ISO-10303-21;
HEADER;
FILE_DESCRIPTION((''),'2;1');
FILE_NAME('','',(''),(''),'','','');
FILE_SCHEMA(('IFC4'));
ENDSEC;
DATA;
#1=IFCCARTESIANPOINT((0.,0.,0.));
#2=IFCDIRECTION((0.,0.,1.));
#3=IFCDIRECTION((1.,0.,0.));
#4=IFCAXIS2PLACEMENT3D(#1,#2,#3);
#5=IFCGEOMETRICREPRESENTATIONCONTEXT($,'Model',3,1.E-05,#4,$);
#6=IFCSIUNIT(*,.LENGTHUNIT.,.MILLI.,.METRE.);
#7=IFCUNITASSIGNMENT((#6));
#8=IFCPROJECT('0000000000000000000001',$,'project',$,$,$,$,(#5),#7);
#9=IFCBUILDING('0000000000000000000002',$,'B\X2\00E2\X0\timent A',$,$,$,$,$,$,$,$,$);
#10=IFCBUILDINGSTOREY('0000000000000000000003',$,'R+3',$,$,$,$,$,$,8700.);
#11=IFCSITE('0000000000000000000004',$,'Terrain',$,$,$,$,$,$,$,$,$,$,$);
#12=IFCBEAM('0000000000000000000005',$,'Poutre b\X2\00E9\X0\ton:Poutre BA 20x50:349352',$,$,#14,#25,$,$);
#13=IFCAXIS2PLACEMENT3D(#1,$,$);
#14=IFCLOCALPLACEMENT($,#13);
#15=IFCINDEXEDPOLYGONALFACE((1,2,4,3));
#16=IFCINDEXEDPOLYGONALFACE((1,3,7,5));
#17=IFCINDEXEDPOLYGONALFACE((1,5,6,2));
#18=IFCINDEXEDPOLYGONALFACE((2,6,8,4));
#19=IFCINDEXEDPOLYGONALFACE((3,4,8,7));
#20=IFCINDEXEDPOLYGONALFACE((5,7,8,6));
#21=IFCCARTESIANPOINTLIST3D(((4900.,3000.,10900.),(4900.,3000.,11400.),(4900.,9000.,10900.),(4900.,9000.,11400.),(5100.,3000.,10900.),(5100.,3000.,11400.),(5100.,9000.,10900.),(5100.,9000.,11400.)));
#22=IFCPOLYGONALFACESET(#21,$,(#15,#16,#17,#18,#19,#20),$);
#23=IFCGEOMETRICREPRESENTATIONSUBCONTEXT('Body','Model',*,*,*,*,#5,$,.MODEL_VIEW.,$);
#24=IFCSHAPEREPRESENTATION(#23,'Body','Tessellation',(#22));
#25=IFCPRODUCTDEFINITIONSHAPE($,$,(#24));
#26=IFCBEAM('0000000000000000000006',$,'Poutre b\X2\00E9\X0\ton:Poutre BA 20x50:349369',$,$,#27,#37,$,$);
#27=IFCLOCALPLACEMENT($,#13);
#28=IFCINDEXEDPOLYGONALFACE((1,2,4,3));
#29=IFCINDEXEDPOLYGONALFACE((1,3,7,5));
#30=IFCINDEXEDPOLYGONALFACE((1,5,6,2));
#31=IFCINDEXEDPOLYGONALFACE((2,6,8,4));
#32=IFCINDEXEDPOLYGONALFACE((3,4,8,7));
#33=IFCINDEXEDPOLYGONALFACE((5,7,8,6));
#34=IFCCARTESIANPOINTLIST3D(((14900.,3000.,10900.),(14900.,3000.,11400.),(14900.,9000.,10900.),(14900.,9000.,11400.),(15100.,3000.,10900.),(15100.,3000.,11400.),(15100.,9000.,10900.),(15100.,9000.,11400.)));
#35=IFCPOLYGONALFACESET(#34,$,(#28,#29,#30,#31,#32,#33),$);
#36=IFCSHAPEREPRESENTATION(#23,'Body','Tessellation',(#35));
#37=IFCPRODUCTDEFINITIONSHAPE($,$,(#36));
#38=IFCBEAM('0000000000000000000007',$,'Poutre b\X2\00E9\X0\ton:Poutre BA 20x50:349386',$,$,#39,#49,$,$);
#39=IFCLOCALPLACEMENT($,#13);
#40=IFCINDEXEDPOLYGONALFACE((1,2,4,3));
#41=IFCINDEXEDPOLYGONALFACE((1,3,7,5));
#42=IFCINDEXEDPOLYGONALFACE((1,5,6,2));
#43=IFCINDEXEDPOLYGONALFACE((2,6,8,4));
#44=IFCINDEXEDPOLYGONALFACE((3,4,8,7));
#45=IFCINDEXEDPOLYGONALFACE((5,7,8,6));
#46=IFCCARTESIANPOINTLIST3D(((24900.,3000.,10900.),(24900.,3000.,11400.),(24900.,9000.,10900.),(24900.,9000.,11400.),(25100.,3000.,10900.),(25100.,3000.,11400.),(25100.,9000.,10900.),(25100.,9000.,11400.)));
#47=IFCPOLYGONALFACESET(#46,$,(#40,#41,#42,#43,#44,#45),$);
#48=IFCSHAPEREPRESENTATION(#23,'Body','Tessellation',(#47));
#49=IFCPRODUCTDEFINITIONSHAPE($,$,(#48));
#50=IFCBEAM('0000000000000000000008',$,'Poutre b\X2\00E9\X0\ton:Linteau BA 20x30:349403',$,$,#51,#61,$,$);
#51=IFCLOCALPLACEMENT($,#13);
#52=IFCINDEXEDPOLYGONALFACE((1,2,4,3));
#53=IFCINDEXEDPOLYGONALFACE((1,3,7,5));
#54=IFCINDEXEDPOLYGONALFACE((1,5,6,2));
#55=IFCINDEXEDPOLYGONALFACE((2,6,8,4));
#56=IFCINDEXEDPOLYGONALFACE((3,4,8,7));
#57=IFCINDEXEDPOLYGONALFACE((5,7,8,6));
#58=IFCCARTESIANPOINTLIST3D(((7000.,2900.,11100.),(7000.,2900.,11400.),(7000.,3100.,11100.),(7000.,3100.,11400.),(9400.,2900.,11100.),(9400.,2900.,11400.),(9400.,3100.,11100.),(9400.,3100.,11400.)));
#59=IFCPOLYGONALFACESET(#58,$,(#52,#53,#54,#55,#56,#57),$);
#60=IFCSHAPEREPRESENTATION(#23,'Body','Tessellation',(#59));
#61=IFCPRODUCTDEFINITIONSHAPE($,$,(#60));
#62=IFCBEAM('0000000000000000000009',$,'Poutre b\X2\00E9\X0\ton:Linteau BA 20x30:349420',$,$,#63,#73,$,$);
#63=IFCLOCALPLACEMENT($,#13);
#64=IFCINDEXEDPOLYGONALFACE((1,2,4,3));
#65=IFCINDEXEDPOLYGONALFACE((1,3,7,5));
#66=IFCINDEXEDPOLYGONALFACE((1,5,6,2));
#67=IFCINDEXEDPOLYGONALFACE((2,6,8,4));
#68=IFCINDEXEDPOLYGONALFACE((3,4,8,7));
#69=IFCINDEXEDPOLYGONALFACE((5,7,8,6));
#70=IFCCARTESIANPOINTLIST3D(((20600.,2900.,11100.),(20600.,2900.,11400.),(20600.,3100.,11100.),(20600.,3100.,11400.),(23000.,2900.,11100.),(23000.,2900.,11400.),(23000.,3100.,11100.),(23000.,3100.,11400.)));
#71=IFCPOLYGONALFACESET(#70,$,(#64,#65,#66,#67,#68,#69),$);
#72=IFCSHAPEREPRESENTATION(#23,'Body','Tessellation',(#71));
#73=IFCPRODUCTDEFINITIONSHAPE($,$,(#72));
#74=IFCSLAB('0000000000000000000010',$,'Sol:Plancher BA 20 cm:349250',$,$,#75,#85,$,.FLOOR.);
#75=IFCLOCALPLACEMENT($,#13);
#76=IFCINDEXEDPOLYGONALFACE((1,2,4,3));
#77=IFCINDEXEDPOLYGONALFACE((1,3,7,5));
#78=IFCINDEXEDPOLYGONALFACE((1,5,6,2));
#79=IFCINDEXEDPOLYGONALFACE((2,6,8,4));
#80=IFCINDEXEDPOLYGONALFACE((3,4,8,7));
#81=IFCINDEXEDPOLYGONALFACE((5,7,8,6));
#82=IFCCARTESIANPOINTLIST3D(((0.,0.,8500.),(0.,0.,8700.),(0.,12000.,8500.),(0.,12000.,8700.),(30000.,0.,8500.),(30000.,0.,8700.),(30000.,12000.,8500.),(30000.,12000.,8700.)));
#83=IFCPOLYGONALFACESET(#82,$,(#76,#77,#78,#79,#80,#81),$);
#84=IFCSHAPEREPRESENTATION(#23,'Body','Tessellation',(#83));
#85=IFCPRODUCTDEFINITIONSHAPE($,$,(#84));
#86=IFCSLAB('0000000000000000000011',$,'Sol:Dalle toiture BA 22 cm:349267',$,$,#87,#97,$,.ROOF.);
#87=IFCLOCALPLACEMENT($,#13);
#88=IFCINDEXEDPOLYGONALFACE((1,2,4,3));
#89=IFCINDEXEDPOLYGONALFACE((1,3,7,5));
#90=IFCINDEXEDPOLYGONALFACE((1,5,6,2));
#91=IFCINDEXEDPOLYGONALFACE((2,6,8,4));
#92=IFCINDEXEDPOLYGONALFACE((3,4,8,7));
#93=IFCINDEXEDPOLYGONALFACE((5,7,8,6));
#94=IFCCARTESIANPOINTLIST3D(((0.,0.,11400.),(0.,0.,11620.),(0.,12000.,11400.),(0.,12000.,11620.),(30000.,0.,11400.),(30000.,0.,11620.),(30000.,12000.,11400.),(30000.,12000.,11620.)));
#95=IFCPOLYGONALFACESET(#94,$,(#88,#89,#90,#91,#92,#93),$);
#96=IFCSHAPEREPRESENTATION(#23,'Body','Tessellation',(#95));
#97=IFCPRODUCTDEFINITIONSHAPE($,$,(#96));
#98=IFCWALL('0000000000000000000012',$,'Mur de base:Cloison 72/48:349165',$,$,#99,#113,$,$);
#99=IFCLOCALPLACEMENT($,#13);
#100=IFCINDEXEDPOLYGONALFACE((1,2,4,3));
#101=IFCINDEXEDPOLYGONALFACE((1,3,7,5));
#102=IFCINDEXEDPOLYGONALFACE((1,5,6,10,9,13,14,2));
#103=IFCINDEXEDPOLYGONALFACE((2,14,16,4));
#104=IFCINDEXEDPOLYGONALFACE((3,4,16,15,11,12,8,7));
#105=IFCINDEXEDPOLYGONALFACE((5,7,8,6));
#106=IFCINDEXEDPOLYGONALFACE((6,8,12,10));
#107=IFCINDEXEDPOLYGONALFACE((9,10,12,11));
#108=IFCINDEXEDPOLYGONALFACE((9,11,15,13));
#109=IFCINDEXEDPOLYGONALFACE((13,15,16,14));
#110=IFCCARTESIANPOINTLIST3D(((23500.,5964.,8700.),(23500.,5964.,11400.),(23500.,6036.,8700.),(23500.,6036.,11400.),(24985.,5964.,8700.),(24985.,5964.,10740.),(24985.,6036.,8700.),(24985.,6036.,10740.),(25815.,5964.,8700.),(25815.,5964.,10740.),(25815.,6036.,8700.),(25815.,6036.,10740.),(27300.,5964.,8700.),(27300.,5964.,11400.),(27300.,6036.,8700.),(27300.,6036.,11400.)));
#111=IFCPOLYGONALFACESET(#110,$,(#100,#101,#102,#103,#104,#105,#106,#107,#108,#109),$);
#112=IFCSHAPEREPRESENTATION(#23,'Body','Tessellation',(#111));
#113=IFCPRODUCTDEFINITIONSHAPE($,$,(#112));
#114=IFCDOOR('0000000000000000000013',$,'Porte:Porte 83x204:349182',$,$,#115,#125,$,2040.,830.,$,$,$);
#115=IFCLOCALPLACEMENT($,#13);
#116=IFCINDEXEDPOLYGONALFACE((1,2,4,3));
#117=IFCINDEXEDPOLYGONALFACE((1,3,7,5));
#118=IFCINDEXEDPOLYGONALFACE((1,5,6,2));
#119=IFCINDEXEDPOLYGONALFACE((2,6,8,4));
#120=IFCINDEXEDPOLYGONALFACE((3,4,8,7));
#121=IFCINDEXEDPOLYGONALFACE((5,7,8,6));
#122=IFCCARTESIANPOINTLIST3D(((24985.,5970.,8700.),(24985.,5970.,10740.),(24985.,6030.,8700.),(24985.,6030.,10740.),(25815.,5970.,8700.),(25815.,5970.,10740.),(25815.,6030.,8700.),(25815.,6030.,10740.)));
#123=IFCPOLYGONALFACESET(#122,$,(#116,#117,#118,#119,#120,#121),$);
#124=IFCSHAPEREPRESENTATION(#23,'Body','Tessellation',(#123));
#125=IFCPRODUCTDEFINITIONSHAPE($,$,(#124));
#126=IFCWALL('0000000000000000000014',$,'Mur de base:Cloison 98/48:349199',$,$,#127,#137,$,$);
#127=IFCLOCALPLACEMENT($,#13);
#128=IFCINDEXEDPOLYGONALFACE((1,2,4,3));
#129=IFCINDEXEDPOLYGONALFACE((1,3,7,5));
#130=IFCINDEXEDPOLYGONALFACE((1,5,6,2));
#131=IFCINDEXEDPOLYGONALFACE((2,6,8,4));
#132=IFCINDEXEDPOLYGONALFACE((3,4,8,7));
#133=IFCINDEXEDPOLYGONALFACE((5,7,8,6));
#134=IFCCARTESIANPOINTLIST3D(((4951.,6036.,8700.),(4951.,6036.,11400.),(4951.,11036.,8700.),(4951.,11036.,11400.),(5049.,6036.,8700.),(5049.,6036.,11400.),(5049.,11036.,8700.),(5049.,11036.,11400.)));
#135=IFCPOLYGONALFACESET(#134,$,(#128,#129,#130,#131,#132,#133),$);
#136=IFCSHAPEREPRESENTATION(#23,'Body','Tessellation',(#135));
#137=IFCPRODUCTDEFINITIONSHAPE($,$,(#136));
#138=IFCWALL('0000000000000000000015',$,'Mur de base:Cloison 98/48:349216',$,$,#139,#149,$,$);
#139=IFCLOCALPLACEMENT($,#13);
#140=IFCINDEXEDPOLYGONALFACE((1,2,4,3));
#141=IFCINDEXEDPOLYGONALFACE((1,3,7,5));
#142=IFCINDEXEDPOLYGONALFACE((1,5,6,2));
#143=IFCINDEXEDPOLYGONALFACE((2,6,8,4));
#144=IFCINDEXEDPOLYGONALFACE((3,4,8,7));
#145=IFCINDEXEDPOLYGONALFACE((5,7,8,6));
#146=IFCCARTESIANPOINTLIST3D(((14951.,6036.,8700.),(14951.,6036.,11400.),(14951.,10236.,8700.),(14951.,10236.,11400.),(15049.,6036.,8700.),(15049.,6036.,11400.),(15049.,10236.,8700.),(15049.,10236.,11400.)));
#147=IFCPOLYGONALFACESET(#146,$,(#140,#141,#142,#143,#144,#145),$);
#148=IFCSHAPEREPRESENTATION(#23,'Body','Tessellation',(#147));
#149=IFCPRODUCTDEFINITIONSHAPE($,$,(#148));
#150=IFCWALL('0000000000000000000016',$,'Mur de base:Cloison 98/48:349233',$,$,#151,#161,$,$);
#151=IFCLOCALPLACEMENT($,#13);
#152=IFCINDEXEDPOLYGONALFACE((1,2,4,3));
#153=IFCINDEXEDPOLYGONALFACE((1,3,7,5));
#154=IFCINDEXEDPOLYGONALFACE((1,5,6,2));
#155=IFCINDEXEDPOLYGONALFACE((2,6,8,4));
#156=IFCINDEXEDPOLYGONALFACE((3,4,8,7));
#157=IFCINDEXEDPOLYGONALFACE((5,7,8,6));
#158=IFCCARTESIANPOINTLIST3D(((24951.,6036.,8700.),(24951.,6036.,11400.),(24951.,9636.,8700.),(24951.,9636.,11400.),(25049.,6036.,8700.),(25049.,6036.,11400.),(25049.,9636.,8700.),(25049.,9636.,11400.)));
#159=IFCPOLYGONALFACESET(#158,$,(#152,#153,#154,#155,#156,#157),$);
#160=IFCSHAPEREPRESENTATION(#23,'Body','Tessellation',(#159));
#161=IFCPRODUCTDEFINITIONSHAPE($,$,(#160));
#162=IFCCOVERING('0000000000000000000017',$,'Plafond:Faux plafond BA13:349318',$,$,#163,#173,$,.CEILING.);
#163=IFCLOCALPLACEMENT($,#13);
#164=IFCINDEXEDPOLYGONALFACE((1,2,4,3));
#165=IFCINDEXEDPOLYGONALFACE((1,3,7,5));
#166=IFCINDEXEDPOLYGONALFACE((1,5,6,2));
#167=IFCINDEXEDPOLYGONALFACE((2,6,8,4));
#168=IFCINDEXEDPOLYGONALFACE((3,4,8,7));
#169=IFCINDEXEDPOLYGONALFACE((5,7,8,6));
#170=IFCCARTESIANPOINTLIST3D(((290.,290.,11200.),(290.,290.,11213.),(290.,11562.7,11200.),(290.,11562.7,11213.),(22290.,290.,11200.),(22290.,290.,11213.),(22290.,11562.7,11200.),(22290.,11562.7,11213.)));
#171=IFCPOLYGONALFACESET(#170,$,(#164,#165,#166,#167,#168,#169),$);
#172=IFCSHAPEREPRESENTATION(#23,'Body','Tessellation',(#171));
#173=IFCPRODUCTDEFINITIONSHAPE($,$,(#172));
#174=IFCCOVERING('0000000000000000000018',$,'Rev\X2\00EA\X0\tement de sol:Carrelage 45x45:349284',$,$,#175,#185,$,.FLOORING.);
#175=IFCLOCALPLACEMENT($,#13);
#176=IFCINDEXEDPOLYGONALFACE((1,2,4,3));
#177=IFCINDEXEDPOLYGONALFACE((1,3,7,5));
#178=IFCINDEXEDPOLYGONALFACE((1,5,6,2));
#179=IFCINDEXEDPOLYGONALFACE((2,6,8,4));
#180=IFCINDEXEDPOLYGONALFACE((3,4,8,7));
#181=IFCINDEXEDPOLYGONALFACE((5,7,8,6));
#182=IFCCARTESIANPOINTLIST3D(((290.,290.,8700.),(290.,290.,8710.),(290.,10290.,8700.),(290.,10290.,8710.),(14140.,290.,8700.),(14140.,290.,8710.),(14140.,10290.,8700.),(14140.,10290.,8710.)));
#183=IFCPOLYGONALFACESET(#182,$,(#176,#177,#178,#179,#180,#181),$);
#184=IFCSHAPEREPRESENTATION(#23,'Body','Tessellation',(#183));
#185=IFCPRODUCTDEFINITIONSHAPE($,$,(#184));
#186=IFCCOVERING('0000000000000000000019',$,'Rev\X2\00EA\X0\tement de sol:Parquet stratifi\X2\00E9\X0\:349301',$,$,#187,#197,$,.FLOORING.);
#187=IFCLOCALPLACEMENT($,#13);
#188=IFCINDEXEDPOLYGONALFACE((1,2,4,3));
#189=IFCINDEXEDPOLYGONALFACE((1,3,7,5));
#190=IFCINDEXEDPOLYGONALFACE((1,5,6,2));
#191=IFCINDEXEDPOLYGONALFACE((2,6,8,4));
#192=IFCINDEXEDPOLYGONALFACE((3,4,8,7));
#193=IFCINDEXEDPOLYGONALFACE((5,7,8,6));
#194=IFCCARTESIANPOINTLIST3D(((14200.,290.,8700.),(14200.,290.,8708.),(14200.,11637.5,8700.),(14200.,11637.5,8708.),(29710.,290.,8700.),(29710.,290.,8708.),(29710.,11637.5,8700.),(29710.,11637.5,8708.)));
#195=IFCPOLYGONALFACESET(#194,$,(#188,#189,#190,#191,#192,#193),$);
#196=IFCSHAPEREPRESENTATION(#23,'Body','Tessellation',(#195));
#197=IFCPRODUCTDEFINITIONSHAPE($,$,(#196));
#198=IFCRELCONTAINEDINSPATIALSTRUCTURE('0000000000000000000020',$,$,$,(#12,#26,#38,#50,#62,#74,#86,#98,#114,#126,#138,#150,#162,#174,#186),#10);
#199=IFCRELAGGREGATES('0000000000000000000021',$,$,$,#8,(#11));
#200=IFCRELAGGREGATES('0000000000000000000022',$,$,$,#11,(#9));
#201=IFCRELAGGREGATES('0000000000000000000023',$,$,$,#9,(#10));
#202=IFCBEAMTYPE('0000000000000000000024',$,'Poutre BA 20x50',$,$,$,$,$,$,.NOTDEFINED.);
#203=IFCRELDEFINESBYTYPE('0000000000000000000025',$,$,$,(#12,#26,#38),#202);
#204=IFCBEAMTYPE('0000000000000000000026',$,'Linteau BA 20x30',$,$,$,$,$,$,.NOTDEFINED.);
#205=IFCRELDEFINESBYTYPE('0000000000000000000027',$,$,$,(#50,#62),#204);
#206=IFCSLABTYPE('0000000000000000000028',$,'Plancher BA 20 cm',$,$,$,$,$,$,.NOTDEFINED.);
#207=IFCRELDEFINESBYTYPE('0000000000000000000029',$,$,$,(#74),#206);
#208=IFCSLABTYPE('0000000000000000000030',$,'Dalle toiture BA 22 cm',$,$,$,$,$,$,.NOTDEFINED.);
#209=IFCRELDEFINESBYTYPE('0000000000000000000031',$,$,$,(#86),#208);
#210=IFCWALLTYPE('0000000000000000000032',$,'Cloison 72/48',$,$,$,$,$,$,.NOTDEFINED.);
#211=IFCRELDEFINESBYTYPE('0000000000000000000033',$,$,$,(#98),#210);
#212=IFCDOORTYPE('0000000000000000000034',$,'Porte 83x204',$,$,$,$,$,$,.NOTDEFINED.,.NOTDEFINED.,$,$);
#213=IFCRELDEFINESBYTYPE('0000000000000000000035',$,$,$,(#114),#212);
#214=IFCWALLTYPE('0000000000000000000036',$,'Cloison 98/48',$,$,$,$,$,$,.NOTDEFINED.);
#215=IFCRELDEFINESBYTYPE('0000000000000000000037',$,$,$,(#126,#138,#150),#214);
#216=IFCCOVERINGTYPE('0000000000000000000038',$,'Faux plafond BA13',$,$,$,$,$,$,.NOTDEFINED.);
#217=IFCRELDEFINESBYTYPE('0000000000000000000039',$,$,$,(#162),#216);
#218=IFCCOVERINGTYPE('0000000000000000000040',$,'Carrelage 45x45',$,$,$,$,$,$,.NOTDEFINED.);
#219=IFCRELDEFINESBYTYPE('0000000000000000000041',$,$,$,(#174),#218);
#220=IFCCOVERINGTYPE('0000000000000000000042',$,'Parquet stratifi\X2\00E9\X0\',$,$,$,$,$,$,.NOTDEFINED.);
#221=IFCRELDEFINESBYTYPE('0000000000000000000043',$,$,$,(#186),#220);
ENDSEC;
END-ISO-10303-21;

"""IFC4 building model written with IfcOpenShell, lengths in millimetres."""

from ifc_helpers import new_model, si_unit, frame, frame_2d, origin_with_axes, place, context, subcontext, project, spatial, rectangle, extrude, type_object, element, fill, save


model = new_model("IFC4")

# Units and contexts
model_context = context("Model", 3, precision=1e-05, world=origin_with_axes())
body_context = subcontext(model_context, "Body", "Model", "MODEL_VIEW")
ifc_project = project(units=[si_unit("LENGTHUNIT", "METRE", prefix="MILLI")], contexts=[model_context])

# Site, building, storey
site = spatial("IfcSite", under=ifc_project, Name="Terrain")
building = spatial("IfcBuilding", under=site, Name="Bâtiment A")
storey = spatial("IfcBuildingStorey", under=building, Name="R+3", Elevation=8700.0)

# Beams
beam_type_1 = type_object("IfcBeamType", Name="Poutre BA 20x50", PredefinedType="NOTDEFINED")
beam_1_placement = place(None, origin_with_axes())
element("IfcBeam", 1, at=beam_1_placement, inside=storey, type_object=beam_type_1, Name="Poutre béton:Poutre BA 20x50:349352", context=body_context, shape_type="SweptSolid", body=[
    extrude(rectangle(XDim=200.0, YDim=6000.0, at=frame_2d((5000.0, 6000.0))), frame((0.0, 0.0, 10900.0), z_axis=(0.0, 0.0, 1.0), x_axis=(1.0, 0.0, 0.0)), (0.0, 0.0, 1.0), 500.0),
])
beam_2_placement = place(None, origin_with_axes())
element("IfcBeam", 2, at=beam_2_placement, inside=storey, type_object=beam_type_1, Name="Poutre béton:Poutre BA 20x50:349369", context=body_context, shape_type="SweptSolid", body=[
    extrude(rectangle(XDim=200.0, YDim=6000.0, at=frame_2d((15000.0, 6000.0))), frame((0.0, 0.0, 10900.0), z_axis=(0.0, 0.0, 1.0), x_axis=(1.0, 0.0, 0.0)), (0.0, 0.0, 1.0), 500.0),
])
beam_3_placement = place(None, origin_with_axes())
element("IfcBeam", 3, at=beam_3_placement, inside=storey, type_object=beam_type_1, Name="Poutre béton:Poutre BA 20x50:349386", context=body_context, shape_type="SweptSolid", body=[
    extrude(rectangle(XDim=200.0, YDim=6000.0, at=frame_2d((25000.0, 6000.0))), frame((0.0, 0.0, 10900.0), z_axis=(0.0, 0.0, 1.0), x_axis=(1.0, 0.0, 0.0)), (0.0, 0.0, 1.0), 500.0),
])
beam_type_2 = type_object("IfcBeamType", Name="Linteau BA 20x30", PredefinedType="NOTDEFINED")
beam_4_placement = place(None, origin_with_axes())
element("IfcBeam", 4, at=beam_4_placement, inside=storey, type_object=beam_type_2, Name="Poutre béton:Linteau BA 20x30:349403", context=body_context, shape_type="SweptSolid", body=[
    extrude(rectangle(XDim=2400.0, YDim=200.0, at=frame_2d((8200.0, 3000.0))), frame((0.0, 0.0, 11100.0), z_axis=(0.0, 0.0, 1.0), x_axis=(1.0, 0.0, 0.0)), (0.0, 0.0, 1.0), 300.0),
])
beam_5_placement = place(None, origin_with_axes())
element("IfcBeam", 5, at=beam_5_placement, inside=storey, type_object=beam_type_2, Name="Poutre béton:Linteau BA 20x30:349420", context=body_context, shape_type="SweptSolid", body=[
    extrude(rectangle(XDim=2400.0, YDim=200.0, at=frame_2d((21800.0, 3000.0))), frame((0.0, 0.0, 11100.0), z_axis=(0.0, 0.0, 1.0), x_axis=(1.0, 0.0, 0.0)), (0.0, 0.0, 1.0), 300.0),
])

# Slabs
slab_type_1 = type_object("IfcSlabType", Name="Plancher BA 20 cm", PredefinedType="NOTDEFINED")
slab_1_placement = place(None, origin_with_axes())
element("IfcSlab", 6, at=slab_1_placement, inside=storey, type_object=slab_type_1, Name="Sol:Plancher BA 20 cm:349250", PredefinedType="FLOOR", context=body_context, shape_type="SweptSolid", body=[
    extrude(rectangle(XDim=30000.0, YDim=12000.0, at=frame_2d((15000.0, 6000.0))), frame((0.0, 0.0, 8500.0), z_axis=(0.0, 0.0, 1.0), x_axis=(1.0, 0.0, 0.0)), (0.0, 0.0, 1.0), 200.0),
])
slab_type_2 = type_object("IfcSlabType", Name="Dalle toiture BA 22 cm", PredefinedType="NOTDEFINED")
slab_2_placement = place(None, origin_with_axes())
element("IfcSlab", 7, at=slab_2_placement, inside=storey, type_object=slab_type_2, Name="Sol:Dalle toiture BA 22 cm:349267", PredefinedType="ROOF", context=body_context, shape_type="SweptSolid", body=[
    extrude(rectangle(XDim=30000.0, YDim=12000.0, at=frame_2d((15000.0, 6000.0))), frame((0.0, 0.0, 11400.0), z_axis=(0.0, 0.0, 1.0), x_axis=(1.0, 0.0, 0.0)), (0.0, 0.0, 1.0), 220.0),
])

# Wall, opening, door
wall_type_1 = type_object("IfcWallType", Name="Cloison 72/48", PredefinedType="NOTDEFINED")
wall_1_placement = place(None, origin_with_axes())
wall_1 = element("IfcWall", 8, at=wall_1_placement, inside=storey, type_object=wall_type_1, Name="Mur de base:Cloison 72/48:349165", context=body_context, shape_type="SweptSolid", body=[
    extrude(rectangle(XDim=3800.0, YDim=72.0, at=frame_2d((25400.0, 6000.0))), frame((0.0, 0.0, 8700.0), z_axis=(0.0, 0.0, 1.0), x_axis=(1.0, 0.0, 0.0)), (0.0, 0.0, 1.0), 2700.0),
])
opening_placement = place(None, origin_with_axes())
opening = element("IfcOpeningElement", 9, at=opening_placement, cuts=wall_1, context=body_context, shape_type="SweptSolid", body=[
    extrude(rectangle(XDim=830.0, YDim=192.0, at=frame_2d((25400.0, 6000.0))), frame((0.0, 0.0, 8700.0), z_axis=(0.0, 0.0, 1.0), x_axis=(1.0, 0.0, 0.0)), (0.0, 0.0, 1.0), 2040.0),
])
door_type = type_object("IfcDoorType", Name="Porte 83x204", OperationType="NOTDEFINED", PredefinedType="NOTDEFINED")
door_placement = place(None, origin_with_axes())
door = element("IfcDoor", 10, at=door_placement, inside=storey, type_object=door_type, Name="Porte:Porte 83x204:349182", OverallHeight=2040.0, OverallWidth=830.0, context=body_context, shape_type="SweptSolid", body=[
    extrude(rectangle(XDim=830.0, YDim=60.0, at=frame_2d((25400.0, 6000.0))), frame((0.0, 0.0, 8700.0), z_axis=(0.0, 0.0, 1.0), x_axis=(1.0, 0.0, 0.0)), (0.0, 0.0, 1.0), 2040.0),
])
fill(opening, door)

# Walls
wall_type_2 = type_object("IfcWallType", Name="Cloison 98/48", PredefinedType="NOTDEFINED")
wall_2_placement = place(None, origin_with_axes())
element("IfcWall", 11, at=wall_2_placement, inside=storey, type_object=wall_type_2, Name="Mur de base:Cloison 98/48:349199", context=body_context, shape_type="SweptSolid", body=[
    extrude(rectangle(XDim=98.0, YDim=5000.0, at=frame_2d((5000.0, 8536.0))), frame((0.0, 0.0, 8700.0), z_axis=(0.0, 0.0, 1.0), x_axis=(1.0, 0.0, 0.0)), (0.0, 0.0, 1.0), 2700.0),
])
wall_3_placement = place(None, origin_with_axes())
element("IfcWall", 12, at=wall_3_placement, inside=storey, type_object=wall_type_2, Name="Mur de base:Cloison 98/48:349216", context=body_context, shape_type="SweptSolid", body=[
    extrude(rectangle(XDim=98.0, YDim=4200.0, at=frame_2d((15000.0, 8136.0))), frame((0.0, 0.0, 8700.0), z_axis=(0.0, 0.0, 1.0), x_axis=(1.0, 0.0, 0.0)), (0.0, 0.0, 1.0), 2700.0),
])
wall_4_placement = place(None, origin_with_axes())
element("IfcWall", 13, at=wall_4_placement, inside=storey, type_object=wall_type_2, Name="Mur de base:Cloison 98/48:349233", context=body_context, shape_type="SweptSolid", body=[
    extrude(rectangle(XDim=98.0, YDim=3600.0, at=frame_2d((25000.0, 7836.0))), frame((0.0, 0.0, 8700.0), z_axis=(0.0, 0.0, 1.0), x_axis=(1.0, 0.0, 0.0)), (0.0, 0.0, 1.0), 2700.0),
])

# Coverings
covering_type_1 = type_object("IfcCoveringType", Name="Faux plafond BA13", PredefinedType="NOTDEFINED")
covering_1_placement = place(None, origin_with_axes())
element("IfcCovering", 14, at=covering_1_placement, inside=storey, type_object=covering_type_1, Name="Plafond:Faux plafond BA13:349318", PredefinedType="CEILING", context=body_context, shape_type="SweptSolid", body=[
    extrude(rectangle(XDim=22000.0, YDim=11272.7, at=frame_2d((11290.0, 5926.4))), frame((0.0, 0.0, 11200.0), z_axis=(0.0, 0.0, 1.0), x_axis=(1.0, 0.0, 0.0)), (0.0, 0.0, 1.0), 13.0),
])
covering_type_2 = type_object("IfcCoveringType", Name="Carrelage 45x45", PredefinedType="NOTDEFINED")
covering_2_placement = place(None, origin_with_axes())
element("IfcCovering", 15, at=covering_2_placement, inside=storey, type_object=covering_type_2, Name="Revêtement de sol:Carrelage 45x45:349284", PredefinedType="FLOORING", context=body_context, shape_type="SweptSolid", body=[
    extrude(rectangle(XDim=13850.0, YDim=10000.0, at=frame_2d((7215.0, 5290.0))), frame((0.0, 0.0, 8700.0), z_axis=(0.0, 0.0, 1.0), x_axis=(1.0, 0.0, 0.0)), (0.0, 0.0, 1.0), 10.0),
])
covering_type_3 = type_object("IfcCoveringType", Name="Parquet stratifié", PredefinedType="NOTDEFINED")
covering_3_placement = place(None, origin_with_axes())
element("IfcCovering", 16, at=covering_3_placement, inside=storey, type_object=covering_type_3, Name="Revêtement de sol:Parquet stratifié:349301", PredefinedType="FLOORING", context=body_context, shape_type="SweptSolid", body=[
    extrude(rectangle(XDim=15510.0, YDim=11347.5, at=frame_2d((21955.0, 5963.8))), frame((0.0, 0.0, 8700.0), z_axis=(0.0, 0.0, 1.0), x_axis=(1.0, 0.0, 0.0)), (0.0, 0.0, 1.0), 8.0),
])

save(model, "model.ifc")
